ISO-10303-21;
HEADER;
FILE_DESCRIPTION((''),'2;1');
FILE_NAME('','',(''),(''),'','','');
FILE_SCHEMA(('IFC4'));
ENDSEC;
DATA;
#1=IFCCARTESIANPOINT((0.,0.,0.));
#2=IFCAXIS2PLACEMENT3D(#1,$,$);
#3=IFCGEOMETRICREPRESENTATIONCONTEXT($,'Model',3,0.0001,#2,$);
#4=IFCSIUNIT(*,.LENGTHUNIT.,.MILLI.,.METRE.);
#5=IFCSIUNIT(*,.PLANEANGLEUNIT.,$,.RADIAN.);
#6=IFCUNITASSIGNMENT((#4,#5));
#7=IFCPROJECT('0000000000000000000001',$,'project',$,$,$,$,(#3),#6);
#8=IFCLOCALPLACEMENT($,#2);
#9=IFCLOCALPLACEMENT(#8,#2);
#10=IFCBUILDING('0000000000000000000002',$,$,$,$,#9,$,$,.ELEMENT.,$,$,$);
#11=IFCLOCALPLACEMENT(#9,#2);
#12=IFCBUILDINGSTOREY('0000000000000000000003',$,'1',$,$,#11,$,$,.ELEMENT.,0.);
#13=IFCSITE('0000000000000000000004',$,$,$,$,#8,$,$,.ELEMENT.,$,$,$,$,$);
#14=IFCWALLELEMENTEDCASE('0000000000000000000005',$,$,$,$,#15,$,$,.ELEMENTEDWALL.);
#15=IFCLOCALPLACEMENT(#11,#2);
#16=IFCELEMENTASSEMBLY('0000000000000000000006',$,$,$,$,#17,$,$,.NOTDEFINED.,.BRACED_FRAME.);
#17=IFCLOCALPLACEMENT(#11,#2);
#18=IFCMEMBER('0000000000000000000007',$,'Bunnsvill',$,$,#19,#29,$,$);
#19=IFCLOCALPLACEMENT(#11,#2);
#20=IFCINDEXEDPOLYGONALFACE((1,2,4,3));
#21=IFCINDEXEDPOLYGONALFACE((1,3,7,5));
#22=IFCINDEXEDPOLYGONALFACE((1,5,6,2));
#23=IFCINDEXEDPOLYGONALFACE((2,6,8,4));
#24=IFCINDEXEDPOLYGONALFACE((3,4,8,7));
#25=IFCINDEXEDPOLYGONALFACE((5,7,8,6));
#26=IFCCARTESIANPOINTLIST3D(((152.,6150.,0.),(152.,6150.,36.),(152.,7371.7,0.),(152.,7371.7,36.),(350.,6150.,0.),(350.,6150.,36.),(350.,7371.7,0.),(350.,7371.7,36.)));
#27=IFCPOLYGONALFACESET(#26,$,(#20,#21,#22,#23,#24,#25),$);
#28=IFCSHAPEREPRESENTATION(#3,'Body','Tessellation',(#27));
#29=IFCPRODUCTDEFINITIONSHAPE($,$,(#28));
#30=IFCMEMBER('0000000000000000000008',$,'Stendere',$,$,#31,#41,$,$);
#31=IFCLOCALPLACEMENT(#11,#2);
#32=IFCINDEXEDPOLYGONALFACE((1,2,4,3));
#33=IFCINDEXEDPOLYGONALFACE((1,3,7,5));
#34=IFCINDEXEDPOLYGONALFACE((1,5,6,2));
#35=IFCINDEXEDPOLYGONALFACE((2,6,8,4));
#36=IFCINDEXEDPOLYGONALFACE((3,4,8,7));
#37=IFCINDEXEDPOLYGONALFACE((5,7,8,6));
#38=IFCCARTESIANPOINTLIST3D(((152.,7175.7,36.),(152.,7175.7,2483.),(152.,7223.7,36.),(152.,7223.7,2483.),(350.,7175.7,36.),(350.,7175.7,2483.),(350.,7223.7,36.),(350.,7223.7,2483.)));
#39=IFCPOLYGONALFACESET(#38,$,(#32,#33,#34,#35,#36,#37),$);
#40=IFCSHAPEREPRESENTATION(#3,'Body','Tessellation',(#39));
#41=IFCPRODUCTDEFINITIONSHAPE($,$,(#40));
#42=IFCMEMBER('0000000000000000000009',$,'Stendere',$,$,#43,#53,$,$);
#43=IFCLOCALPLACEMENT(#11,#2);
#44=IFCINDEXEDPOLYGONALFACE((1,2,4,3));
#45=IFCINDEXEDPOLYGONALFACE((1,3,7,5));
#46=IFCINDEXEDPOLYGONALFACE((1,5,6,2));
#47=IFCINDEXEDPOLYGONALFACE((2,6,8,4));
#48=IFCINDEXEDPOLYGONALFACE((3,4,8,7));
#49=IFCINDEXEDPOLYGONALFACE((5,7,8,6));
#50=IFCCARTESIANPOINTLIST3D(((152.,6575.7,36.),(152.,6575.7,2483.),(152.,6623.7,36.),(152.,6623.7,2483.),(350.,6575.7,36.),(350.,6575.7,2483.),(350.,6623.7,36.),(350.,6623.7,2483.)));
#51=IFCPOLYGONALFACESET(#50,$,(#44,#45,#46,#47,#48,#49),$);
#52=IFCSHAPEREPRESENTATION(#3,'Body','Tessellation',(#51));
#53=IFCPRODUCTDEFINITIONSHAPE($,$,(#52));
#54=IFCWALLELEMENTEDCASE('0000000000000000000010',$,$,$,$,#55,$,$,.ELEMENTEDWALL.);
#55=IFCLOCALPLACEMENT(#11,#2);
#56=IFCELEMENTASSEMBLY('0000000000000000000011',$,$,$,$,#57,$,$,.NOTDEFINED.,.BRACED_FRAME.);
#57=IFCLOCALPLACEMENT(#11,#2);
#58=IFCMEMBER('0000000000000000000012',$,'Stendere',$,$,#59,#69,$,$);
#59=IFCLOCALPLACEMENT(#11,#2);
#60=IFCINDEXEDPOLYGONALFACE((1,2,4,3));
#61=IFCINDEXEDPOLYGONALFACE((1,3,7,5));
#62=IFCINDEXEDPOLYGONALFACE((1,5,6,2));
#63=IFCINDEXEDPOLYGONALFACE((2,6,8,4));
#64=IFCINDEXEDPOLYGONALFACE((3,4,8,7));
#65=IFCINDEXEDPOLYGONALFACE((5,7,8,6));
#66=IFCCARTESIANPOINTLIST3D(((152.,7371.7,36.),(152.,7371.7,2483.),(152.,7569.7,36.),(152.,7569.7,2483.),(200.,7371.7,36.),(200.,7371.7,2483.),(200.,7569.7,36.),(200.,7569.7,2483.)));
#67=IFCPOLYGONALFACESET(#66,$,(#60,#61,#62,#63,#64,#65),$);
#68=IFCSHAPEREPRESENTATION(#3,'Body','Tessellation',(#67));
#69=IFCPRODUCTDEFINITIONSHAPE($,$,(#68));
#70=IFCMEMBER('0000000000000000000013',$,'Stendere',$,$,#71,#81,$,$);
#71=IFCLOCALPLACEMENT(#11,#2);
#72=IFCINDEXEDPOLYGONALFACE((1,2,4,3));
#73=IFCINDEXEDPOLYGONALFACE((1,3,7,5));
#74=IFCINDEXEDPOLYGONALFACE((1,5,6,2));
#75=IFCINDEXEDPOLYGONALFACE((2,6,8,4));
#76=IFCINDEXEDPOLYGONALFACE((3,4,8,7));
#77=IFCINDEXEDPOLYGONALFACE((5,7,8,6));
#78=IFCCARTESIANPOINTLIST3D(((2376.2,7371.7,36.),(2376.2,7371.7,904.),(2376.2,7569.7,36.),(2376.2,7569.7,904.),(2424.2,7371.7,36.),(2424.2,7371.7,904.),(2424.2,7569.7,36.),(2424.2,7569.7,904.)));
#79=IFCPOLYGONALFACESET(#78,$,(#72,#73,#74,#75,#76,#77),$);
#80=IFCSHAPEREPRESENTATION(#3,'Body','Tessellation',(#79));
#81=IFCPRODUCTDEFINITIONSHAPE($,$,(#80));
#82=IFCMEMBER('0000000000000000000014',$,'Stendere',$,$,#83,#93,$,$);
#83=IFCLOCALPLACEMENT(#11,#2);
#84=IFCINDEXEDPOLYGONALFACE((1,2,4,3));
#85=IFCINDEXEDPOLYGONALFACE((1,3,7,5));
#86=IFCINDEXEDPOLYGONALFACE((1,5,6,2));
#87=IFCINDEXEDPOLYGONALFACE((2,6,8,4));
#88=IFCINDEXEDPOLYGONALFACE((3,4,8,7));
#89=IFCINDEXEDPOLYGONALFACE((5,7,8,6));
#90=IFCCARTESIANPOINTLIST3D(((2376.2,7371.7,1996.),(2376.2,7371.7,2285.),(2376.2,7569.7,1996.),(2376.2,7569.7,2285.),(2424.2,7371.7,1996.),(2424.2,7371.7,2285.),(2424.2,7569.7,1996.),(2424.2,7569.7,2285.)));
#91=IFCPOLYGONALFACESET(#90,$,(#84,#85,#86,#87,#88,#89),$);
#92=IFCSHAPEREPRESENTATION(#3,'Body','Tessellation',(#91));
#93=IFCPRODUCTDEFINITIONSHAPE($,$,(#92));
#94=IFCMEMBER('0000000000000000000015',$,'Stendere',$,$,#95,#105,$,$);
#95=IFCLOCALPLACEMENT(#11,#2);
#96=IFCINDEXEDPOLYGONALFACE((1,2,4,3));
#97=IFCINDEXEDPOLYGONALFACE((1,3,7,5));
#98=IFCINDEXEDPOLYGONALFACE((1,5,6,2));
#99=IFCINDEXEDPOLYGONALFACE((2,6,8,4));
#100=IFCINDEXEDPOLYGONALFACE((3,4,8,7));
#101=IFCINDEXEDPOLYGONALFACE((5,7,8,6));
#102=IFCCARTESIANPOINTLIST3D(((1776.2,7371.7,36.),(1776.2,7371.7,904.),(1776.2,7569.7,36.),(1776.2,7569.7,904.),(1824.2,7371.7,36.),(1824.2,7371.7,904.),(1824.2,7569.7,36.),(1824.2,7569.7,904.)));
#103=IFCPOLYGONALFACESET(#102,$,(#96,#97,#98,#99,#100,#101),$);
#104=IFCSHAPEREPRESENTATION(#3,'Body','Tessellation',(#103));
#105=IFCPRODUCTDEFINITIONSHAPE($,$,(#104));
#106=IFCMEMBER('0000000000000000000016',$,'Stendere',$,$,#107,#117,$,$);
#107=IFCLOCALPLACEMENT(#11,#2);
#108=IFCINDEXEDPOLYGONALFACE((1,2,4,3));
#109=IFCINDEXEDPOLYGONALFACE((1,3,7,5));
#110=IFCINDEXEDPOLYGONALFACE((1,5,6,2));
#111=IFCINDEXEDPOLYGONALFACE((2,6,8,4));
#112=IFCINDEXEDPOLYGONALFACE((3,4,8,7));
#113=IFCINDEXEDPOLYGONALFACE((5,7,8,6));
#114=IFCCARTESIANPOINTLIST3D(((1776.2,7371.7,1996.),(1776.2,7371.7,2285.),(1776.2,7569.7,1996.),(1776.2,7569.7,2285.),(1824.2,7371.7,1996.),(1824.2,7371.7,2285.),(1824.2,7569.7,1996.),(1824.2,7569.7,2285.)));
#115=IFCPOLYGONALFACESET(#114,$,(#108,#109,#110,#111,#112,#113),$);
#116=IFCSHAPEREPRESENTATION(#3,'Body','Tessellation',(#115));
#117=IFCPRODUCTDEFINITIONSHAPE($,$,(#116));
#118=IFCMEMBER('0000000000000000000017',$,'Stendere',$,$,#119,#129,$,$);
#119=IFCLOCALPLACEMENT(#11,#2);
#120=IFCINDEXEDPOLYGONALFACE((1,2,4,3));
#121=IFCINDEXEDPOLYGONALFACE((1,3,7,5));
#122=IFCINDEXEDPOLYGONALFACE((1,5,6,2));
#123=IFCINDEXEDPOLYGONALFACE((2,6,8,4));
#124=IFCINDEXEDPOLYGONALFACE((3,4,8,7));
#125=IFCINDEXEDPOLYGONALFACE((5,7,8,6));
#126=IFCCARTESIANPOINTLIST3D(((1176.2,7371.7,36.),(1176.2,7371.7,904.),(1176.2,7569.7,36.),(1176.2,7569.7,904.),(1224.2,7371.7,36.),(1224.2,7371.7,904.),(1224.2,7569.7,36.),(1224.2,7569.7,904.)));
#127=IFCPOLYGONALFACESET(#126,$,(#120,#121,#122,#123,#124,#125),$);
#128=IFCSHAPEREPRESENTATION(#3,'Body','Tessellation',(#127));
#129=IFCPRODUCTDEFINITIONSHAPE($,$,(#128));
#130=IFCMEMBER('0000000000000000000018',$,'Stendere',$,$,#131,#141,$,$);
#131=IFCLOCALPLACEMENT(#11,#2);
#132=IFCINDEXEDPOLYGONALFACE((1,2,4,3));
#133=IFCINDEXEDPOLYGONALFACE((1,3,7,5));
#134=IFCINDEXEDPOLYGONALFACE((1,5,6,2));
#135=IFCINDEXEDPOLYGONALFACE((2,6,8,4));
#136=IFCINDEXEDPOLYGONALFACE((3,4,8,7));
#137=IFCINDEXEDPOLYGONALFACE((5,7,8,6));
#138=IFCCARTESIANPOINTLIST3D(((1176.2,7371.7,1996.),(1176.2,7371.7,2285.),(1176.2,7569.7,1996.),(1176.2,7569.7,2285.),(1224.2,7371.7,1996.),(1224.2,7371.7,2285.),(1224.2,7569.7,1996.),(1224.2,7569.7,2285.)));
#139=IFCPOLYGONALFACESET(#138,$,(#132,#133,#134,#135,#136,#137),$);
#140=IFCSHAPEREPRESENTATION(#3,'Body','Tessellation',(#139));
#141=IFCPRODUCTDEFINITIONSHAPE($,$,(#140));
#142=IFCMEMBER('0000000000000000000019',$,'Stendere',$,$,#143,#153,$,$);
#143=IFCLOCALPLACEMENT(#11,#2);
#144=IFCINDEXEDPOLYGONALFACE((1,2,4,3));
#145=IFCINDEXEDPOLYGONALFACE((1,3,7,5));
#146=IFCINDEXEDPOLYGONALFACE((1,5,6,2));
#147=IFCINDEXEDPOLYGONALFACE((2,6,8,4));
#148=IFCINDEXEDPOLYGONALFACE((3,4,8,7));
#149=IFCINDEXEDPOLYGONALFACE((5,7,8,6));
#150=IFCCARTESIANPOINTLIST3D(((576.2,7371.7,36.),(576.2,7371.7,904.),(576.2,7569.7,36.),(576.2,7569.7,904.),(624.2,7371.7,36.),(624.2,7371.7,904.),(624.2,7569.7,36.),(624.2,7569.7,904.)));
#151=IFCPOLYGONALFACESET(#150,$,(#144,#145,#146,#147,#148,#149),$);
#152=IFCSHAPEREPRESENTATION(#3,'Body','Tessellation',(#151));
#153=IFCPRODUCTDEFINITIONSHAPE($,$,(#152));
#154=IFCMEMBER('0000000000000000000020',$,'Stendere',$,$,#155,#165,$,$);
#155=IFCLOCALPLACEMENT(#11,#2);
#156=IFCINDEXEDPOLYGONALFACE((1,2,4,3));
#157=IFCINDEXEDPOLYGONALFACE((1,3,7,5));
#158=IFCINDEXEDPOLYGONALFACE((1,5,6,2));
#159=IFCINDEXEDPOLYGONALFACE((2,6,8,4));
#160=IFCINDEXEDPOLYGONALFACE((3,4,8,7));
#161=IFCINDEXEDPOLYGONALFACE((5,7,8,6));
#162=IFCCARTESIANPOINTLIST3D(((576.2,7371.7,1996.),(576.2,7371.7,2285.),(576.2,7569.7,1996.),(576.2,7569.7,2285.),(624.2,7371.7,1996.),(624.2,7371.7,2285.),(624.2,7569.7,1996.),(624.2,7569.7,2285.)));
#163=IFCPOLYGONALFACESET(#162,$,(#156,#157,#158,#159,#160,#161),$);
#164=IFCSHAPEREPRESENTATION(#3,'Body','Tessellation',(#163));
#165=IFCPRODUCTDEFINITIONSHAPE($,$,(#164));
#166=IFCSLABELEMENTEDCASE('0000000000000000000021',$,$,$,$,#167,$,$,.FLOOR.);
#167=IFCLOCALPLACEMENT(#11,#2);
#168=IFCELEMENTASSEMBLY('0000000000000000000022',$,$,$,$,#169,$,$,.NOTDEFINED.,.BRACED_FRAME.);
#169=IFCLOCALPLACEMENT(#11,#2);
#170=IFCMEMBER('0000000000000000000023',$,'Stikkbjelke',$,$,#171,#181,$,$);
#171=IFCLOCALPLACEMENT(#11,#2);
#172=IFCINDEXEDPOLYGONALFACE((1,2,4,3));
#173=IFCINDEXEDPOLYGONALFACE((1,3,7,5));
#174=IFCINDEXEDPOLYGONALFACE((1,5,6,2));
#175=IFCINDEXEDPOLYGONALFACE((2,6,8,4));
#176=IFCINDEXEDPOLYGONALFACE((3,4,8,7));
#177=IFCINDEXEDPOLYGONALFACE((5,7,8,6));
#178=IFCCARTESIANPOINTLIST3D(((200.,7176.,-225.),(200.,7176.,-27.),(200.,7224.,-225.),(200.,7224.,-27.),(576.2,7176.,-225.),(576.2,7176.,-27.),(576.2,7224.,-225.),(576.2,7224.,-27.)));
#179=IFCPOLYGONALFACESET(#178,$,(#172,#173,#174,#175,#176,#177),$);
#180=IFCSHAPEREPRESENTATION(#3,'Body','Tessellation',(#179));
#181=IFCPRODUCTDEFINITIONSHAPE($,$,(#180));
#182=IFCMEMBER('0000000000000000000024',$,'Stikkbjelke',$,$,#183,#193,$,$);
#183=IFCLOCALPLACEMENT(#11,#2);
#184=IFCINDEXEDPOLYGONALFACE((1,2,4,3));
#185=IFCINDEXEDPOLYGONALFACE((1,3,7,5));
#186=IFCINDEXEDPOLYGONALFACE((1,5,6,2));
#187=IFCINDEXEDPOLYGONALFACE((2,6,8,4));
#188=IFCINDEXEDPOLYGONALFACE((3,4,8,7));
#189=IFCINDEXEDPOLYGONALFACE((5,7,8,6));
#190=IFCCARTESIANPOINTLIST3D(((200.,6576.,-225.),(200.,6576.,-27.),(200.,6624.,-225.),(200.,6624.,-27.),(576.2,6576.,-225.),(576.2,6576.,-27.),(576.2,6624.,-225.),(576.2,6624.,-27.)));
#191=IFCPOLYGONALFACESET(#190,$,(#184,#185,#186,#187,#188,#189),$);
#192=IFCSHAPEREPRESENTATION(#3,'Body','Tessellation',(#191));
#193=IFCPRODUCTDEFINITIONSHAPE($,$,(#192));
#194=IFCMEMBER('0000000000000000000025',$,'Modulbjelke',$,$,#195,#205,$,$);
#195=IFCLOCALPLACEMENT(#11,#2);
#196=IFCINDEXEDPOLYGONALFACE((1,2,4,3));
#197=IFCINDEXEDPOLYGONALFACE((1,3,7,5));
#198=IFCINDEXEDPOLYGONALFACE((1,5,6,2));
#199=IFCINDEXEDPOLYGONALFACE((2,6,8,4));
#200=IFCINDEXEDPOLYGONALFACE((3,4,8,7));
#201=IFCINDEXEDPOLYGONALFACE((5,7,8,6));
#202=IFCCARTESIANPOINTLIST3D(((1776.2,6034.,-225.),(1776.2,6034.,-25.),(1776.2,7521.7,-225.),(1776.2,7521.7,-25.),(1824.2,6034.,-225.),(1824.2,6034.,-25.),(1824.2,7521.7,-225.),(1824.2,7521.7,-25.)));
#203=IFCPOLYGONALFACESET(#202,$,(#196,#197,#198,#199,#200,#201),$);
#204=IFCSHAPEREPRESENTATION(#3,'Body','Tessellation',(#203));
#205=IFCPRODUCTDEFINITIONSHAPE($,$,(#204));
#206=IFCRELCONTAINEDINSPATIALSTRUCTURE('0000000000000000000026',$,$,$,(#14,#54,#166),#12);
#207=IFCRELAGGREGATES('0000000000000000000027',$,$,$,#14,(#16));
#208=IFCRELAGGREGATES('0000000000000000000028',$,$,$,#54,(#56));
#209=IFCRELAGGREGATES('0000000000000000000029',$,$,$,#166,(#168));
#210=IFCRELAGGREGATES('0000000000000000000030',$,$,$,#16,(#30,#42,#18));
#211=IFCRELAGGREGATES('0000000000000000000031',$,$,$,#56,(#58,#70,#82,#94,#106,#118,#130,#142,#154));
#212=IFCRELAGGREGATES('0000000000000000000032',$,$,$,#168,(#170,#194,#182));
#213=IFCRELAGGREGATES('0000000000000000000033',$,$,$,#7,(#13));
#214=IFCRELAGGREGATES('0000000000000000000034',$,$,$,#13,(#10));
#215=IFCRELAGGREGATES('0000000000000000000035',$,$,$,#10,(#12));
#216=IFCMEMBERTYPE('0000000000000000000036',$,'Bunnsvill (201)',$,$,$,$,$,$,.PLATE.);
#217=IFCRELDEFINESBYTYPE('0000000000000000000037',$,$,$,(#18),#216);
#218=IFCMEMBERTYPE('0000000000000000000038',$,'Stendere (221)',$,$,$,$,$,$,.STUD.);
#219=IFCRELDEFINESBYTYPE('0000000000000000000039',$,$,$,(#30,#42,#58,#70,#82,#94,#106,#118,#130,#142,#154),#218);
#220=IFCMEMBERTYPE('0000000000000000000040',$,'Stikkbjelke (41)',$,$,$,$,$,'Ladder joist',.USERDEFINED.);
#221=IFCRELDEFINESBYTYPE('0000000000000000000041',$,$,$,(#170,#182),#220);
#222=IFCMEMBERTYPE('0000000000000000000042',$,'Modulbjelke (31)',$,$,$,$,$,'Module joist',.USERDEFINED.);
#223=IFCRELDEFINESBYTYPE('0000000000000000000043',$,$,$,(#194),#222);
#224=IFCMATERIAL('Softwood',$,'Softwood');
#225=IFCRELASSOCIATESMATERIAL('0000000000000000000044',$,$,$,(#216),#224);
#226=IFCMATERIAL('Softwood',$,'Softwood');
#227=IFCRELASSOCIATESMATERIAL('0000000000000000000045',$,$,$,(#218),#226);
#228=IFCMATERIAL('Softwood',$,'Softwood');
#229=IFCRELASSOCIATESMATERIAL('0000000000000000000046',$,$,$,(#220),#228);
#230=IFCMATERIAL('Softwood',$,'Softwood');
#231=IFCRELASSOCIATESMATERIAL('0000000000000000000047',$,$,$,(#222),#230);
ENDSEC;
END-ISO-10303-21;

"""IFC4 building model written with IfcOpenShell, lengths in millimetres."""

from ifc_helpers import new_model, si_unit, frame, origin, place, context, project, spatial, rectangle, extrude, clip, halfspace, material, material_profile, profile_set, type_object, element, aggregate, save


model = new_model("IFC4")

# Units and contexts
model_context = context("Model", 3, precision=0.0001, world=origin())
ifc_project = project(units=[si_unit("LENGTHUNIT", "METRE", prefix="MILLI"), si_unit("PLANEANGLEUNIT", "RADIAN")], contexts=[model_context])

# Site, building, storey
site_placement = place(None, origin())
site = spatial("IfcSite", under=ifc_project, at=site_placement, CompositionType="ELEMENT")
building_placement = place(site_placement, origin())
building = spatial("IfcBuilding", under=site, at=building_placement, CompositionType="ELEMENT")
storey_placement = place(building_placement, origin())
storey = spatial("IfcBuildingStorey", under=building, at=storey_placement, Name="1", CompositionType="ELEMENT", Elevation=0.0)

# Walls, element assemblies, members
wall_1_placement = place(storey_placement, frame((350.0, 7371.7, 0.0), z_axis=(-1.0, 0.0, 0.0), x_axis=(0.0, -1.0, 0.0)))
wall_1 = element("IfcWallElementedCase", 1, at=wall_1_placement, inside=storey, PredefinedType="ELEMENTEDWALL")
assembly_1_placement = place(wall_1_placement, origin())
assembly_1 = element("IfcElementAssembly", 2, at=assembly_1_placement, AssemblyPlace="NOTDEFINED", PredefinedType="BRACED_FRAME")
aggregate(wall_1, [assembly_1])
ifc_material_1 = material(Name="Softwood", Category="Softwood")
ifc_material_profile_1 = material_profile(ifc_material_1, rectangle(XDim=36.0, YDim=198.0), Name="Bunnsvill (201)")
ifc_profile_set_1 = profile_set([ifc_material_profile_1])
member_type_1 = type_object("IfcMemberType", Name="Bunnsvill (201)", PredefinedType="PLATE", material=ifc_profile_set_1)
member_1_placement = place(assembly_1_placement, frame((0.0, 18.0, 0.0), z_axis=(1.0, 0.0, 0.0), x_axis=(0.0, 1.0, 0.0)))
member_1 = element("IfcMember", 3, at=member_1_placement, type_object=member_type_1, Name="Bunnsvill", context=model_context, shape_type="SweptSolid", body=[
    extrude(rectangle(XDim=36.0, YDim=198.0), frame((0.0, 99.0, 0.0)), (0.0, 0.0, 1.0), 1221.7),
])
ifc_material_2 = material(Name="Softwood", Category="Softwood")
ifc_material_profile_2 = material_profile(ifc_material_2, rectangle(XDim=48.0, YDim=198.0), Name="Stendere (221)")
ifc_profile_set_2 = profile_set([ifc_material_profile_2])
member_type_2 = type_object("IfcMemberType", Name="Stendere (221)", PredefinedType="STUD", material=ifc_profile_set_2)
member_2_placement = place(assembly_1_placement, frame((172.0, 36.0, 0.0), z_axis=(0.0, 1.0, 0.0), x_axis=(-1.0, 0.0, 0.0)))
member_2 = element("IfcMember", 4, at=member_2_placement, type_object=member_type_2, Name="Stendere", context=model_context, shape_type="SweptSolid", body=[
    extrude(rectangle(XDim=48.0, YDim=198.0), frame((0.0, 99.0, 0.0)), (0.0, 0.0, 1.0), 2447.0),
])
member_3_placement = place(assembly_1_placement, frame((772.0, 36.0, 0.0), z_axis=(0.0, 1.0, 0.0), x_axis=(-1.0, 0.0, 0.0)))
member_3 = element("IfcMember", 5, at=member_3_placement, type_object=member_type_2, Name="Stendere", context=model_context, shape_type="SweptSolid", body=[
    extrude(rectangle(XDim=48.0, YDim=198.0), frame((0.0, 99.0, 0.0)), (0.0, 0.0, 1.0), 2447.0),
])
wall_2_placement = place(storey_placement, frame((5348.2, 7371.7, 0.0), z_axis=(0.0, 1.0, 0.0), x_axis=(-1.0, 0.0, 0.0)))
wall_2 = element("IfcWallElementedCase", 6, at=wall_2_placement, inside=storey, PredefinedType="ELEMENTEDWALL")
assembly_2_placement = place(wall_2_placement, origin())
assembly_2 = element("IfcElementAssembly", 7, at=assembly_2_placement, AssemblyPlace="NOTDEFINED", PredefinedType="BRACED_FRAME")
aggregate(wall_2, [assembly_2])
member_4_placement = place(assembly_2_placement, frame((5172.2, 36.0, 0.0), z_axis=(0.0, 1.0, 0.0), x_axis=(-1.0, 0.0, 0.0)))
member_4 = element("IfcMember", 8, at=member_4_placement, type_object=member_type_2, Name="Stendere", context=model_context, shape_type="SweptSolid", body=[
    extrude(rectangle(XDim=48.0, YDim=198.0), frame((0.0, 99.0, 0.0)), (0.0, 0.0, 1.0), 2447.0),
])
member_5_placement = place(assembly_2_placement, frame((2948.0, 36.0, 0.0), z_axis=(0.0, 1.0, 0.0), x_axis=(-1.0, 0.0, 0.0)))
member_5 = element("IfcMember", 9, at=member_5_placement, type_object=member_type_2, Name="Stendere", context=model_context, shape_type="SweptSolid", body=[
    extrude(rectangle(XDim=48.0, YDim=198.0), frame((0.0, 99.0, 0.0)), (0.0, 0.0, 1.0), 868.0),
])
member_6_placement = place(assembly_2_placement, frame((2948.0, 1996.0, 0.0), z_axis=(0.0, 1.0, 0.0), x_axis=(-1.0, 0.0, 0.0)))
member_6 = element("IfcMember", 10, at=member_6_placement, type_object=member_type_2, Name="Stendere", context=model_context, shape_type="SweptSolid", body=[
    extrude(rectangle(XDim=48.0, YDim=198.0), frame((0.0, 99.0, 0.0)), (0.0, 0.0, 1.0), 289.0),
])
member_7_placement = place(assembly_2_placement, frame((3548.0, 36.0, 0.0), z_axis=(0.0, 1.0, 0.0), x_axis=(-1.0, 0.0, 0.0)))
member_7 = element("IfcMember", 11, at=member_7_placement, type_object=member_type_2, Name="Stendere", context=model_context, shape_type="SweptSolid", body=[
    extrude(rectangle(XDim=48.0, YDim=198.0), frame((0.0, 99.0, 0.0)), (0.0, 0.0, 1.0), 868.0),
])
member_8_placement = place(assembly_2_placement, frame((3548.0, 1996.0, 0.0), z_axis=(0.0, 1.0, 0.0), x_axis=(-1.0, 0.0, 0.0)))
member_8 = element("IfcMember", 12, at=member_8_placement, type_object=member_type_2, Name="Stendere", context=model_context, shape_type="SweptSolid", body=[
    extrude(rectangle(XDim=48.0, YDim=198.0), frame((0.0, 99.0, 0.0)), (0.0, 0.0, 1.0), 289.0),
])
member_9_placement = place(assembly_2_placement, frame((4148.0, 36.0, 0.0), z_axis=(0.0, 1.0, 0.0), x_axis=(-1.0, 0.0, 0.0)))
member_9 = element("IfcMember", 13, at=member_9_placement, type_object=member_type_2, Name="Stendere", context=model_context, shape_type="SweptSolid", body=[
    extrude(rectangle(XDim=48.0, YDim=198.0), frame((0.0, 99.0, 0.0)), (0.0, 0.0, 1.0), 868.0),
])
member_10_placement = place(assembly_2_placement, frame((4148.0, 1996.0, 0.0), z_axis=(0.0, 1.0, 0.0), x_axis=(-1.0, 0.0, 0.0)))
member_10 = element("IfcMember", 14, at=member_10_placement, type_object=member_type_2, Name="Stendere", context=model_context, shape_type="SweptSolid", body=[
    extrude(rectangle(XDim=48.0, YDim=198.0), frame((0.0, 99.0, 0.0)), (0.0, 0.0, 1.0), 289.0),
])
member_11_placement = place(assembly_2_placement, frame((4748.0, 36.0, 0.0), z_axis=(0.0, 1.0, 0.0), x_axis=(-1.0, 0.0, 0.0)))
member_11 = element("IfcMember", 15, at=member_11_placement, type_object=member_type_2, Name="Stendere", context=model_context, shape_type="SweptSolid", body=[
    extrude(rectangle(XDim=48.0, YDim=198.0), frame((0.0, 99.0, 0.0)), (0.0, 0.0, 1.0), 868.0),
])
member_12_placement = place(assembly_2_placement, frame((4748.0, 1996.0, 0.0), z_axis=(0.0, 1.0, 0.0), x_axis=(-1.0, 0.0, 0.0)))
member_12 = element("IfcMember", 16, at=member_12_placement, type_object=member_type_2, Name="Stendere", context=model_context, shape_type="SweptSolid", body=[
    extrude(rectangle(XDim=48.0, YDim=198.0), frame((0.0, 99.0, 0.0)), (0.0, 0.0, 1.0), 289.0),
])

# Slab, element assembly, members
slab_placement = place(storey_placement, origin())
slab = element("IfcSlabElementedCase", 17, at=slab_placement, inside=storey, PredefinedType="FLOOR")
assembly_3_placement = place(slab_placement, frame((0.0, 0.0, -225.0)))
assembly_3 = element("IfcElementAssembly", 18, at=assembly_3_placement, AssemblyPlace="NOTDEFINED", PredefinedType="BRACED_FRAME")
aggregate(slab, [assembly_3])
ifc_material_3 = material(Name="Softwood", Category="Softwood")
ifc_material_profile_3 = material_profile(ifc_material_3, rectangle(XDim=48.0, YDim=198.0), Name="Stikkbjelke (41)")
ifc_profile_set_3 = profile_set([ifc_material_profile_3])
member_type_3 = type_object("IfcMemberType", Name="Stikkbjelke (41)", ElementType="Ladder joist", PredefinedType="USERDEFINED", material=ifc_profile_set_3)
member_13_placement = place(assembly_3_placement, frame((200.0, 7200.0, 0.0), z_axis=(1.0, 0.0, 0.0), x_axis=(0.0, 1.0, 0.0)))
member_13 = element("IfcMember", 19, at=member_13_placement, type_object=member_type_3, Name="Stikkbjelke", context=model_context, shape_type="SweptSolid", body=[
    extrude(rectangle(XDim=48.0, YDim=198.0), frame((0.0, 99.0, 0.0)), (0.0, 0.0, 1.0), 376.2),
])
member_14_placement = place(assembly_3_placement, frame((200.0, 6600.0, 0.0), z_axis=(1.0, 0.0, 0.0), x_axis=(0.0, 1.0, 0.0)))
member_14 = element("IfcMember", 20, at=member_14_placement, type_object=member_type_3, Name="Stikkbjelke", context=model_context, shape_type="SweptSolid", body=[
    extrude(rectangle(XDim=48.0, YDim=198.0), frame((0.0, 99.0, 0.0)), (0.0, 0.0, 1.0), 376.2),
])
ifc_material_4 = material(Name="Softwood", Category="Softwood")
ifc_material_profile_4 = material_profile(ifc_material_4, rectangle(XDim=48.0, YDim=200.0), Name="Modulbjelke (31)")
ifc_profile_set_4 = profile_set([ifc_material_profile_4])
member_type_4 = type_object("IfcMemberType", Name="Modulbjelke (31)", ElementType="Module joist", PredefinedType="USERDEFINED", material=ifc_profile_set_4)
member_15_placement = place(assembly_3_placement, frame((1800.2, 6034.0, 0.0), z_axis=(0.000001, 1.0, 0.0), x_axis=(-1.0, 0.000001, 0.0)))
member_15 = element("IfcMember", 21, at=member_15_placement, type_object=member_type_4, Name="Modulbjelke", context=model_context, shape_type="Clipping", body=[
    clip(clip(extrude(rectangle(XDim=48.0, YDim=200.0), frame((0.0, 100.0, 0.0)), (0.0, 0.0, 1.0), 1487.7), halfspace(frame((0.0, 100.0, 0.0)), True)), halfspace(frame((0.0, 100.0, 1487.7)), False)),
])

aggregate(assembly_1, [member_2, member_3, member_1])

aggregate(assembly_2, [member_4, member_5, member_6, member_7, member_8, member_9, member_10, member_11, member_12])
aggregate(assembly_3, [member_13, member_15, member_14])

save(model, "model.ifc")
